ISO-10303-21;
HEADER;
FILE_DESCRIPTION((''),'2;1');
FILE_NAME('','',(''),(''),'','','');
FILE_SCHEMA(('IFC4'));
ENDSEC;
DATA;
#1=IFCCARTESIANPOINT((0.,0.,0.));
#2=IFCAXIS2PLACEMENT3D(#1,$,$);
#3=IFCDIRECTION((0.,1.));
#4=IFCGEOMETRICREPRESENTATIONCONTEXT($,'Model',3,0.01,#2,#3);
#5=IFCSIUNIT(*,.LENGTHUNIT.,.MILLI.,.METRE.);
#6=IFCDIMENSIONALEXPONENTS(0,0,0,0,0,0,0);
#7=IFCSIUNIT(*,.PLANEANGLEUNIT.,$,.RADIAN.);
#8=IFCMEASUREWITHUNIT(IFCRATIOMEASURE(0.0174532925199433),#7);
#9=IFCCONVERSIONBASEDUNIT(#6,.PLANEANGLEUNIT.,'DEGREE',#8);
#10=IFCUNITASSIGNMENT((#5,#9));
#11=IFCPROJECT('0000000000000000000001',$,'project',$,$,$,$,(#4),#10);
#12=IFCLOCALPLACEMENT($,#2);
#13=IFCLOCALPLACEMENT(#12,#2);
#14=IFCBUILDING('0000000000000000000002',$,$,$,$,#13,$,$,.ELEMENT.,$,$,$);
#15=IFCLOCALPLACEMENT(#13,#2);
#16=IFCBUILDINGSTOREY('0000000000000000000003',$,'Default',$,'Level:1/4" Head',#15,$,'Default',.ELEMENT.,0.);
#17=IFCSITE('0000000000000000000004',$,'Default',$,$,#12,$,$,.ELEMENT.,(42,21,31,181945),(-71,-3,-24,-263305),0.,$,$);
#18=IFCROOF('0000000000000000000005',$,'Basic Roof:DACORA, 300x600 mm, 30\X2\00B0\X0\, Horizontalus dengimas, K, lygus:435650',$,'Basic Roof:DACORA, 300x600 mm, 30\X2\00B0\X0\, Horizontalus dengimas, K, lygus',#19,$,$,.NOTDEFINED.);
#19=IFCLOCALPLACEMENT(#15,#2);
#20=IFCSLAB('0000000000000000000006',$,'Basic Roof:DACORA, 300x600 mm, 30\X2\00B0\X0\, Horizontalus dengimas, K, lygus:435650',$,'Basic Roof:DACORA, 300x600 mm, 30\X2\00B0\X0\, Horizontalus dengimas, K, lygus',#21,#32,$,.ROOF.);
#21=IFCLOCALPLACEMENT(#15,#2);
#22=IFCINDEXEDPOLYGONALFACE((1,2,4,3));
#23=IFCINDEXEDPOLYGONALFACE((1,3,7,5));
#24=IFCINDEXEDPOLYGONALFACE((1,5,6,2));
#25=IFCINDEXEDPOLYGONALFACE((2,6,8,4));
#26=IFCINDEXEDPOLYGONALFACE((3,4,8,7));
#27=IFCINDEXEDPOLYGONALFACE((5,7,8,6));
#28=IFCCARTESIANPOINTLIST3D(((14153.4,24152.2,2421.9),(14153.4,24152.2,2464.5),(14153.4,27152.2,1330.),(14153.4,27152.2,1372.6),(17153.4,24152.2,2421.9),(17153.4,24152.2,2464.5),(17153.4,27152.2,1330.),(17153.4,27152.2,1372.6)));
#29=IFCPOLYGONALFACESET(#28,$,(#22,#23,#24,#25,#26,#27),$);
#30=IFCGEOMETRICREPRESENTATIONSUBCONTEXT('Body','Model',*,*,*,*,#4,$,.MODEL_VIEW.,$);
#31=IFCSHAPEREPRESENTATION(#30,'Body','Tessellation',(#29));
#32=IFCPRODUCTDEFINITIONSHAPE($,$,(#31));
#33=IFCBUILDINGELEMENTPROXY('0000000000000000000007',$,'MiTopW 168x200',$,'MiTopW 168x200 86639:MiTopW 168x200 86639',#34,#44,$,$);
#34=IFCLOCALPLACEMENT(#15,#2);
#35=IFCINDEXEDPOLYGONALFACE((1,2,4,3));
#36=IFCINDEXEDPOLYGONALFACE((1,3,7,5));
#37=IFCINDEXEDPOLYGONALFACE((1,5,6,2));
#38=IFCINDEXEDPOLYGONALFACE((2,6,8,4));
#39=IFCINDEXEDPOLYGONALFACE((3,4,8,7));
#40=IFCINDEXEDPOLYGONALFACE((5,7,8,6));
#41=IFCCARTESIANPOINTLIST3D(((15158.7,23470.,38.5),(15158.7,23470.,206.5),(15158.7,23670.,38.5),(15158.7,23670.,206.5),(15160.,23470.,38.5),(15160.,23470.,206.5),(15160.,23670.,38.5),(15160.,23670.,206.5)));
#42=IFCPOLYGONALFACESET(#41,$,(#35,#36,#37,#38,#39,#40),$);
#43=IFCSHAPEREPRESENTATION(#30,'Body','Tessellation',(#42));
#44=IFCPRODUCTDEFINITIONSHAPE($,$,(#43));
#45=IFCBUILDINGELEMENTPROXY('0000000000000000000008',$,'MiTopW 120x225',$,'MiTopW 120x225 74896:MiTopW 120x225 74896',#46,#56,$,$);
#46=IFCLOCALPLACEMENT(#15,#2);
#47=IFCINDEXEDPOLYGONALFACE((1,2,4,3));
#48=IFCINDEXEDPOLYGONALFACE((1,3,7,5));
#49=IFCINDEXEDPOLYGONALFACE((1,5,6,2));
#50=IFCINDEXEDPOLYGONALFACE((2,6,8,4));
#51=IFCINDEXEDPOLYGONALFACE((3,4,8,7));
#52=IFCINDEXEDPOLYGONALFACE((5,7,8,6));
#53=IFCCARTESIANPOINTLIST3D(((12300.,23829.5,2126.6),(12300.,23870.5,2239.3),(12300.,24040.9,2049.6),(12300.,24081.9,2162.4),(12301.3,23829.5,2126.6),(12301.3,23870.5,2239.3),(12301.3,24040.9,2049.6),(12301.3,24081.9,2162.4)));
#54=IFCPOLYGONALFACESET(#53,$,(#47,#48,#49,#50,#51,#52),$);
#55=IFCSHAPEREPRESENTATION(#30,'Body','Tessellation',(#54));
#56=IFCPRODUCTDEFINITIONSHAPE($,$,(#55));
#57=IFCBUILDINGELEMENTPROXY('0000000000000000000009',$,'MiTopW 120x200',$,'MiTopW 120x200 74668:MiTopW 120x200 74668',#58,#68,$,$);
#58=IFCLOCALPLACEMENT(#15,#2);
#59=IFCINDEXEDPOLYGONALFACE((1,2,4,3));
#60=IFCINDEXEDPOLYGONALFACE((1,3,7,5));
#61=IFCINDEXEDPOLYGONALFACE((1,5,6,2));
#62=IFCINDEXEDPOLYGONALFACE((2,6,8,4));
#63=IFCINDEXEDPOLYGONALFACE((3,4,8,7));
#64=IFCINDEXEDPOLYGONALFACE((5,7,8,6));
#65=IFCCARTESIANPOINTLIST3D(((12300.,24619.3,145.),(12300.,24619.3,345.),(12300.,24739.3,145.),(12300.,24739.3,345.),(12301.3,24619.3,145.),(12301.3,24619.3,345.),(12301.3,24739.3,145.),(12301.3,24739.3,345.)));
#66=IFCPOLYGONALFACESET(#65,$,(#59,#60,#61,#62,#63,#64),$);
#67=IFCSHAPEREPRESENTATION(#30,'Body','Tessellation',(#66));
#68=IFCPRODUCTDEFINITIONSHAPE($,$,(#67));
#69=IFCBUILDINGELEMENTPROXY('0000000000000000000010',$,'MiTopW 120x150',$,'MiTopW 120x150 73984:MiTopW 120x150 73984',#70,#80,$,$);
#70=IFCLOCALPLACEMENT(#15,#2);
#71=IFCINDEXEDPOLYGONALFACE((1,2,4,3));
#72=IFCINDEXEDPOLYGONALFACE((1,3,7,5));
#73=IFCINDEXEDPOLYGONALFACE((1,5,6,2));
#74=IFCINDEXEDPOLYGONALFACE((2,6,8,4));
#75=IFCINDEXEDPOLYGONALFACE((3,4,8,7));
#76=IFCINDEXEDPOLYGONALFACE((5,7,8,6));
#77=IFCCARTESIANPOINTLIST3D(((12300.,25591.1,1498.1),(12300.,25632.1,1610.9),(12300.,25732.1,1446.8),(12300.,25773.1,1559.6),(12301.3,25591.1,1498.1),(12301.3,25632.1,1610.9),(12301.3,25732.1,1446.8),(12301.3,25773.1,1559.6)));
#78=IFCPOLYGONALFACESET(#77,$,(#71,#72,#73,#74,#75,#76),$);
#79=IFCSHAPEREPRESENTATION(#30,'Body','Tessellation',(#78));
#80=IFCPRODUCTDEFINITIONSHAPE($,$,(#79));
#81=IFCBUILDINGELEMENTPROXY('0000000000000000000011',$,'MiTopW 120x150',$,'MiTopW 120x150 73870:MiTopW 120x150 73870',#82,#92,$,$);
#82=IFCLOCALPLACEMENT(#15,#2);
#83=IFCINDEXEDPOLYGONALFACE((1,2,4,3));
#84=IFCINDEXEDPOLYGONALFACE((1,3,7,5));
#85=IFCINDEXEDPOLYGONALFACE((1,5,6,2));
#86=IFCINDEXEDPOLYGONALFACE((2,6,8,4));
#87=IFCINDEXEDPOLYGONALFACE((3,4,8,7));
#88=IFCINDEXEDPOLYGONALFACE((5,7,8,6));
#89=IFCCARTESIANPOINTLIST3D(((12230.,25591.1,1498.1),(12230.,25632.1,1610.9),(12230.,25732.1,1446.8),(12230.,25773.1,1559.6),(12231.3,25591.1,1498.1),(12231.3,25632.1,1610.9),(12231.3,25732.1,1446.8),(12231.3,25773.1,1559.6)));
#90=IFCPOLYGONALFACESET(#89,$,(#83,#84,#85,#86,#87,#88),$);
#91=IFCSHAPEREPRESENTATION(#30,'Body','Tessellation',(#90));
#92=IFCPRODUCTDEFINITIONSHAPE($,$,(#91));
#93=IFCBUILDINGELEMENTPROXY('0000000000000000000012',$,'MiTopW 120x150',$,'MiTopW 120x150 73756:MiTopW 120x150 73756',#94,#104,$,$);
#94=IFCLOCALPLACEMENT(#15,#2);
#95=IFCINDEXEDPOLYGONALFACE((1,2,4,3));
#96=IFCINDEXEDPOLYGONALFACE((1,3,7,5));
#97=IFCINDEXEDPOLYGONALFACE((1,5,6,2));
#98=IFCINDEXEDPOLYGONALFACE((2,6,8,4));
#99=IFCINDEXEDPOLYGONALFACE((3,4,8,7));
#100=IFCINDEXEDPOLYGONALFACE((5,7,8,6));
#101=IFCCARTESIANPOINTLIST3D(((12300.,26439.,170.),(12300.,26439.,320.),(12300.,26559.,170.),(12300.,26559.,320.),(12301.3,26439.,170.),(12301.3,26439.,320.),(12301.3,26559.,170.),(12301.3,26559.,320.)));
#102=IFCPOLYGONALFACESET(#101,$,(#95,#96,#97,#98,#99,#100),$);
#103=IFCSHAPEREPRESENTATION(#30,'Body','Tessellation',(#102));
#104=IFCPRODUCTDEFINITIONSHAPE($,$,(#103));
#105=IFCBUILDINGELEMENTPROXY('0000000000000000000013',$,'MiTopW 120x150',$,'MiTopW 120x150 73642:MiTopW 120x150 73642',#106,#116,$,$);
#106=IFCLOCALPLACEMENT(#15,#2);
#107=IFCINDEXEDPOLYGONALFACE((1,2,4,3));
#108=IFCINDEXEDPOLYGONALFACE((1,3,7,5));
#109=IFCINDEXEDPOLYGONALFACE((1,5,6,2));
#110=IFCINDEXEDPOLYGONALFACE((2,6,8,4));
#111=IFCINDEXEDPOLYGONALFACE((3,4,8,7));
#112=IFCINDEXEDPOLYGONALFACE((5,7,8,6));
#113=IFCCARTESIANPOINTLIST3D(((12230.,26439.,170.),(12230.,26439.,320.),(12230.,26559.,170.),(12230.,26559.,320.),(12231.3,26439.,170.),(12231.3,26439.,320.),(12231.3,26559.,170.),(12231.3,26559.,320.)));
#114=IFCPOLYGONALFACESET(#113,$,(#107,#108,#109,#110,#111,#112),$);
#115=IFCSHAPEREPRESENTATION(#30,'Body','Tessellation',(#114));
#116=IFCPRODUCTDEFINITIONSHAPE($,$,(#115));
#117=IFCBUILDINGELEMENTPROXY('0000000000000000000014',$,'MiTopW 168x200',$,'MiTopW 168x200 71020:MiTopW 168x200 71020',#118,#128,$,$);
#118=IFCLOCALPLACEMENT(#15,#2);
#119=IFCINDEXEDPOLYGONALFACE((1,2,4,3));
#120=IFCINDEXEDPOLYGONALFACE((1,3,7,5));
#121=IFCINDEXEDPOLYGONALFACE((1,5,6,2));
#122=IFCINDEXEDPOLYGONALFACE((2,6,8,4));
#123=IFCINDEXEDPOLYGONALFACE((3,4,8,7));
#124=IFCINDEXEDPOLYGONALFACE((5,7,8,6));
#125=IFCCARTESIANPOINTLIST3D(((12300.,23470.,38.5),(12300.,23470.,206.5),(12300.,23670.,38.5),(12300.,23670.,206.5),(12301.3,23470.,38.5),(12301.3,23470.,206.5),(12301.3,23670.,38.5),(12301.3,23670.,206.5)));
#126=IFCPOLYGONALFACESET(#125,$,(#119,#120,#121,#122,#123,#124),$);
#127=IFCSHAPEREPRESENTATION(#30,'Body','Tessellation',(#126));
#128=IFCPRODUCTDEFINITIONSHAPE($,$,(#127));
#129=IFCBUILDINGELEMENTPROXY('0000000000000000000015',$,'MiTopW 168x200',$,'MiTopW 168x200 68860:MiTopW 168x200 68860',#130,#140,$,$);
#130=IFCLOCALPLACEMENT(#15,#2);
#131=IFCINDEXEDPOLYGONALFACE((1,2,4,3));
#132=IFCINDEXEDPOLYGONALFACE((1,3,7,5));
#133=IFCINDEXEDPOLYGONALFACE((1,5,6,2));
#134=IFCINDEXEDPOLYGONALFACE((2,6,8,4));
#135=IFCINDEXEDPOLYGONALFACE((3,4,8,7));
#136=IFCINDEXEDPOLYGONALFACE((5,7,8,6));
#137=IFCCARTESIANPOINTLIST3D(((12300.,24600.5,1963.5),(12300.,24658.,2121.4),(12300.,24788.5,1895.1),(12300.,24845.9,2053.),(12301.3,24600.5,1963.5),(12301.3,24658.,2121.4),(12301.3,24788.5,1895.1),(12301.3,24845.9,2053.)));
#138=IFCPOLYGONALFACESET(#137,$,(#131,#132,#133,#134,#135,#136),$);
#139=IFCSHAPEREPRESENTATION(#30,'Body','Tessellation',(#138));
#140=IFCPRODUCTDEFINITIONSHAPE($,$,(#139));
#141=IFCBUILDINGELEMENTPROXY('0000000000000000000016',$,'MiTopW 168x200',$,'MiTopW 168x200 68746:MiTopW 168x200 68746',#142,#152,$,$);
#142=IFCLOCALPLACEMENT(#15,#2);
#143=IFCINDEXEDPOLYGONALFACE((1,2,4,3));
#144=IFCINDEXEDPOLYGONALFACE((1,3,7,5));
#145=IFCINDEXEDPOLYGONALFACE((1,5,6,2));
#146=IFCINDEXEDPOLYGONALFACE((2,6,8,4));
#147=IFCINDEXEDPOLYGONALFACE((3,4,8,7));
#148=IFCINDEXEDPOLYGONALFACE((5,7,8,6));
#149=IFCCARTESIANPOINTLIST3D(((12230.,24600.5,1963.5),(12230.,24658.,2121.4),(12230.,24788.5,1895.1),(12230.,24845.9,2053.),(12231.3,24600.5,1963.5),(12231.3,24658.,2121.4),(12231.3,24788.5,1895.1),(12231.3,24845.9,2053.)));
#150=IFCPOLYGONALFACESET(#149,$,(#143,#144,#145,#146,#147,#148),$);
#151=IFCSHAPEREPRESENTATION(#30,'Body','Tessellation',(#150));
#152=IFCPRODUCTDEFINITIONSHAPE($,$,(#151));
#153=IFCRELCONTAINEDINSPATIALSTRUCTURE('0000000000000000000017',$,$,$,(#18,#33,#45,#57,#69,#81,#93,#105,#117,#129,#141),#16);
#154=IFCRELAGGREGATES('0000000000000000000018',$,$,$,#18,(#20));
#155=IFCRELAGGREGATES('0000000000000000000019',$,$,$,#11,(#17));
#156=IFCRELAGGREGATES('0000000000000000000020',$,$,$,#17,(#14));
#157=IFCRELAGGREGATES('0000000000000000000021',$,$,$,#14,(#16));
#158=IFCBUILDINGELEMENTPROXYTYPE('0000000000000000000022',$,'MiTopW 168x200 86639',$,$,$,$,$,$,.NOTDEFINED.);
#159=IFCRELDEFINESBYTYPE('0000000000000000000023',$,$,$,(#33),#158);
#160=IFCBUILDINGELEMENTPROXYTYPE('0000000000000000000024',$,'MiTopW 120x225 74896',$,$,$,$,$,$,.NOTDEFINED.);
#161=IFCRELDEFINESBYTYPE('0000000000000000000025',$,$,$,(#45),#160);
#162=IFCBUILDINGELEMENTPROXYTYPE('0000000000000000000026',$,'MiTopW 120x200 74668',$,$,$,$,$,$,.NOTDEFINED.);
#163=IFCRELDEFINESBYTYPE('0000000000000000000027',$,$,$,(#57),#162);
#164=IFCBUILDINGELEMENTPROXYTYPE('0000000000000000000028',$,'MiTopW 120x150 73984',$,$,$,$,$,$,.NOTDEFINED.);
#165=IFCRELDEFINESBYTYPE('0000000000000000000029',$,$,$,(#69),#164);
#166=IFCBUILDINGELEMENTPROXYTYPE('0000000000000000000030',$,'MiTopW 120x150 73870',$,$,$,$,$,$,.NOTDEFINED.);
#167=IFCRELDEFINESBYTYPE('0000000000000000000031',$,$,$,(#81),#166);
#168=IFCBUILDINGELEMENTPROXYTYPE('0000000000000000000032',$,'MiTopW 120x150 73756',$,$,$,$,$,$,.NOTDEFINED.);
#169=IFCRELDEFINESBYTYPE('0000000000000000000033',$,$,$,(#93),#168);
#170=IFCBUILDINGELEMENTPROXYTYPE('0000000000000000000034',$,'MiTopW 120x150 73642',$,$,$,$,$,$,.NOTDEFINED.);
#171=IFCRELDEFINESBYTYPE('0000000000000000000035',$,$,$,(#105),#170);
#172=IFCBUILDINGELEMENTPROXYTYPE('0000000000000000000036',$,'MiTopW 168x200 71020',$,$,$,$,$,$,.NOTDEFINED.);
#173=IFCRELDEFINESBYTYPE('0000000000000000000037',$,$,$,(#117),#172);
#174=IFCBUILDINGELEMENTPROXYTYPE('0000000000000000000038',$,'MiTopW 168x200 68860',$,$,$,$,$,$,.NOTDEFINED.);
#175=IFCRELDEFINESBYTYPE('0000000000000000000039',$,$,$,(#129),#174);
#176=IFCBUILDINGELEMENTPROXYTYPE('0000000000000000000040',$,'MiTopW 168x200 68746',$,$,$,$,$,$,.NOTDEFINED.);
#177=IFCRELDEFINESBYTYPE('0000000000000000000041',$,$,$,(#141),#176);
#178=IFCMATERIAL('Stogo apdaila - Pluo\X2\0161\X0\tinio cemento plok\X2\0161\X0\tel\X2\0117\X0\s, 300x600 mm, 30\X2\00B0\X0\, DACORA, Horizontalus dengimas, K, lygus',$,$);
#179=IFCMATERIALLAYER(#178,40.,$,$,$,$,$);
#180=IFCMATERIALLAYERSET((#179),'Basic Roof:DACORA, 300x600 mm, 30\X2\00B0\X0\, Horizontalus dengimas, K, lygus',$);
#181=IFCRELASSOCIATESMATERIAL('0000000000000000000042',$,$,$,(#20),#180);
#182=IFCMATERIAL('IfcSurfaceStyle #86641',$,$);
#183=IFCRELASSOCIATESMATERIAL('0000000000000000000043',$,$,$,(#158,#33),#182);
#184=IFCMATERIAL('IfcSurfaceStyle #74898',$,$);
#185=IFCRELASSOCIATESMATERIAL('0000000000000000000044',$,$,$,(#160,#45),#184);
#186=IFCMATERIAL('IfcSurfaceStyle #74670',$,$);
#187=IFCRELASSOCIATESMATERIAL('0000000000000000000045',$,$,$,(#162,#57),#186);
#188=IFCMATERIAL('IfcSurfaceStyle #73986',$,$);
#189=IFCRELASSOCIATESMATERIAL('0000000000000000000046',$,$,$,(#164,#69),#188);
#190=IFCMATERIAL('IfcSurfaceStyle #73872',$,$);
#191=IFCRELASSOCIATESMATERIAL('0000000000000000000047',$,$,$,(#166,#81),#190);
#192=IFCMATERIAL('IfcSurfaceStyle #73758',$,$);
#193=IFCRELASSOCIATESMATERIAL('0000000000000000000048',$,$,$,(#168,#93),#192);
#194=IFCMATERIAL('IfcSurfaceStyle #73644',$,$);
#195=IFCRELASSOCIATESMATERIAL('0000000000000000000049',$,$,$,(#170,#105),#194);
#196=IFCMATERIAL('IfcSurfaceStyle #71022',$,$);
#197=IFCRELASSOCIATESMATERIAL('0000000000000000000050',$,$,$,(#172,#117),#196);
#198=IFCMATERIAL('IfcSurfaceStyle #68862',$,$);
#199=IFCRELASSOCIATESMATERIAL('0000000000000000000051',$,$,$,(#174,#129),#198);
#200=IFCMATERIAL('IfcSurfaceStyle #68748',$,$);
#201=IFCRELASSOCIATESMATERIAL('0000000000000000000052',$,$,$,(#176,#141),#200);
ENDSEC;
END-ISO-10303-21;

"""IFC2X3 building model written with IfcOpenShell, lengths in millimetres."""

from ifc_helpers import new_model, entity, si_unit, converted_unit, direction, frame, frame_2d, origin, origin_2d_with_axis, place, context, subcontext, project, spatial, polyline, rectangle, outline, extrude, source, transform, mapped, material, layer, layer_set, type_object, type_shapes, element, aggregate, save


model = new_model("IFC2X3")

# Units and contexts
model_context = context("Model", 3, precision=0.01, world=origin(), true_north=direction((0.0, 1.0)))
body_context = subcontext(model_context, "Body", "Model", "MODEL_VIEW")
ifc_project = project(units=[si_unit("LENGTHUNIT", "METRE", prefix="MILLI"), converted_unit("PLANEANGLEUNIT", "DEGREE", entity("IfcRatioMeasure", 0.0174532925199433), si_unit("PLANEANGLEUNIT", "RADIAN"), dimensions=[0, 0, 0, 0, 0, 0, 0])], contexts=[model_context])

# Site, building, storey
site_placement = place(None, origin())
site = spatial("IfcSite", under=ifc_project, at=site_placement, Name="Default", CompositionType="ELEMENT", RefLatitude=(42, 21, 31, 181945), RefLongitude=(-71, -3, -24, -263305), RefElevation=0.0)
building_placement = place(site_placement, origin())
building = spatial("IfcBuilding", under=site, at=building_placement, CompositionType="ELEMENT")
storey_placement = place(building_placement, origin())
storey = spatial("IfcBuildingStorey", under=building, at=storey_placement, Name="Default", ObjectType="Level:1/4\" Head", LongName="Default", CompositionType="ELEMENT", Elevation=0.0)

# Roof, slab
roof_placement = place(storey_placement, frame((14153.4, 24152.2, 1330.0)))
roof = element("IfcRoof", 1, at=roof_placement, inside=storey, Name="Basic Roof:DACORA, 300x600 mm, 30°, Horizontalus dengimas, K, lygus:435650", ObjectType="Basic Roof:DACORA, 300x600 mm, 30°, Horizontalus dengimas, K, lygus", ShapeType="NOTDEFINED")
ifc_material_1 = material(Name="Stogo apdaila - Pluoštinio cemento plokštelės, 300x600 mm, 30°, DACORA, Horizontalus dengimas, K, lygus")
ifc_layer = layer(ifc_material_1, 40.0)
ifc_layer_set = layer_set([ifc_layer], Name="Basic Roof:DACORA, 300x600 mm, 30°, Horizontalus dengimas, K, lygus")
slab_placement = place(roof_placement, origin())
slab = element("IfcSlab", 2, at=slab_placement, material=ifc_layer_set, Name="Basic Roof:DACORA, 300x600 mm, 30°, Horizontalus dengimas, K, lygus:435650", ObjectType="Basic Roof:DACORA, 300x600 mm, 30°, Horizontalus dengimas, K, lygus", PredefinedType="ROOF", context=body_context, shape_type="SweptSolid", body=[
    extrude(rectangle(XDim=3192.5, YDim=3000.0, at=frame_2d((0.0, 0.0), x_axis=(0.0, 1.0))), frame((1500.0, 1500.0, 546.0), z_axis=(0.0, 0.34202, 0.939693), x_axis=(1.0, 0.0, 0.0)), (0.0, -0.34202, 0.939693), 42.6),
])
aggregate(roof, [slab])

# Building element proxies
ifc_material_2 = material(Name="IfcSurfaceStyle #86641")
building_element_proxy_type_1 = type_object("IfcBuildingElementProxyType", Name="MiTopW 168x200 86639", PredefinedType="NOTDEFINED", material=ifc_material_2)
shared_shape_1 = source(origin(), body_context, "Body", "SweptSolid", [
    extrude(rectangle(XDim=200.0, YDim=168.0, at=origin_2d_with_axis()), frame((100.0, 84.0, 0.0), z_axis=(0.0, 0.0, 1.0), x_axis=(-1.0, 0.0, 0.0)), (0.0, 0.0, 1.0), 1.3),
])
type_shapes(building_element_proxy_type_1, [shared_shape_1])
proxy_1_placement = place(building_placement, frame((15160.0, 23470.0, 206.5), z_axis=(-1.0, 0.0, 0.0), x_axis=(0.0, 1.0, 0.0)))
element("IfcBuildingElementProxy", 3, at=proxy_1_placement, inside=storey, type_object=building_element_proxy_type_1, material=ifc_material_2, Name="MiTopW 168x200", ObjectType="MiTopW 168x200 86639:MiTopW 168x200 86639", context=body_context, shape_type="MappedRepresentation", body=[
    mapped(shared_shape_1, transform((0.0, 0.0, 0.0), scale=1.0)),
])
ifc_material_3 = material(Name="IfcSurfaceStyle #74898")
building_element_proxy_type_2 = type_object("IfcBuildingElementProxyType", Name="MiTopW 120x225 74896", PredefinedType="NOTDEFINED", material=ifc_material_3)
shared_shape_2 = source(origin(), body_context, "Body", "SweptSolid", [
    extrude(outline(polyline([(-112.5, -60.0), (112.5, -60.0), (112.5, 60.0), (-112.5, 60.0), (-112.5, -60.0)])), frame((112.5, 60.0, 0.0), z_axis=(0.0, 0.0, 1.0), x_axis=(-1.0, 0.0, 0.0)), (0.0, 0.0, 1.0), 1.3),
])
type_shapes(building_element_proxy_type_2, [shared_shape_2])
proxy_2_placement = place(building_placement, frame((12301.3, 24040.9, 2049.6), z_axis=(-1.0, 0.0, 0.0), x_axis=(0.0, -0.939693, 0.34202)))
element("IfcBuildingElementProxy", 4, at=proxy_2_placement, inside=storey, type_object=building_element_proxy_type_2, material=ifc_material_3, Name="MiTopW 120x225", ObjectType="MiTopW 120x225 74896:MiTopW 120x225 74896", context=body_context, shape_type="MappedRepresentation", body=[
    mapped(shared_shape_2, transform((0.0, 0.0, 0.0), scale=1.0)),
])
ifc_material_4 = material(Name="IfcSurfaceStyle #74670")
building_element_proxy_type_3 = type_object("IfcBuildingElementProxyType", Name="MiTopW 120x200 74668", PredefinedType="NOTDEFINED", material=ifc_material_4)
shared_shape_3 = source(origin(), body_context, "Body", "SweptSolid", [
    extrude(rectangle(XDim=200.0, YDim=120.0, at=origin_2d_with_axis()), frame((100.0, 60.0, 0.0), z_axis=(0.0, 0.0, 1.0), x_axis=(-1.0, 0.0, 0.0)), (0.0, 0.0, 1.0), 1.3),
])
type_shapes(building_element_proxy_type_3, [shared_shape_3])
proxy_3_placement = place(building_placement, frame((12301.3, 24619.3, 145.0), z_axis=(-1.0, 0.0, 0.0), x_axis=(0.0, 0.0, 1.0)))
element("IfcBuildingElementProxy", 5, at=proxy_3_placement, inside=storey, type_object=building_element_proxy_type_3, material=ifc_material_4, Name="MiTopW 120x200", ObjectType="MiTopW 120x200 74668:MiTopW 120x200 74668", context=body_context, shape_type="MappedRepresentation", body=[
    mapped(shared_shape_3, transform((0.0, 0.0, 0.0), scale=1.0)),
])
ifc_material_5 = material(Name="IfcSurfaceStyle #73986")
building_element_proxy_type_4 = type_object("IfcBuildingElementProxyType", Name="MiTopW 120x150 73984", PredefinedType="NOTDEFINED", material=ifc_material_5)
shared_shape_4 = source(origin(), body_context, "Body", "SweptSolid", [
    extrude(outline(polyline([(-75.0, -60.0), (75.0, -60.0), (75.0, 60.0), (-75.0, 60.0), (-75.0, -60.0)])), frame((75.0, 60.0, 0.0), z_axis=(0.0, 0.0, 1.0), x_axis=(-1.0, 0.0, 0.0)), (0.0, 0.0, 1.0), 1.3),
])
type_shapes(building_element_proxy_type_4, [shared_shape_4])
proxy_4_placement = place(building_placement, frame((12301.3, 25732.1, 1446.8), z_axis=(-1.0, 0.0, 0.0), x_axis=(0.0, -0.939693, 0.34202)))
element("IfcBuildingElementProxy", 6, at=proxy_4_placement, inside=storey, type_object=building_element_proxy_type_4, material=ifc_material_5, Name="MiTopW 120x150", ObjectType="MiTopW 120x150 73984:MiTopW 120x150 73984", context=body_context, shape_type="MappedRepresentation", body=[
    mapped(shared_shape_4, transform((0.0, 0.0, 0.0), scale=1.0)),
])
ifc_material_6 = material(Name="IfcSurfaceStyle #73872")
building_element_proxy_type_5 = type_object("IfcBuildingElementProxyType", Name="MiTopW 120x150 73870", PredefinedType="NOTDEFINED", material=ifc_material_6)
shared_shape_5 = source(origin(), body_context, "Body", "SweptSolid", [
    extrude(outline(polyline([(-75.0, -60.0), (75.0, -60.0), (75.0, 60.0), (-75.0, 60.0), (-75.0, -60.0)])), frame((75.0, 60.0, 0.0), z_axis=(0.0, 0.0, 1.0), x_axis=(-1.0, 0.0, 0.0)), (0.0, 0.0, 1.0), 1.3),
])
type_shapes(building_element_proxy_type_5, [shared_shape_5])
proxy_5_placement = place(building_placement, frame((12231.3, 25732.1, 1446.8), z_axis=(-1.0, 0.0, 0.0), x_axis=(0.0, -0.939693, 0.34202)))
element("IfcBuildingElementProxy", 7, at=proxy_5_placement, inside=storey, type_object=building_element_proxy_type_5, material=ifc_material_6, Name="MiTopW 120x150", ObjectType="MiTopW 120x150 73870:MiTopW 120x150 73870", context=body_context, shape_type="MappedRepresentation", body=[
    mapped(shared_shape_5, transform((0.0, 0.0, 0.0), scale=1.0)),
])
ifc_material_7 = material(Name="IfcSurfaceStyle #73758")
building_element_proxy_type_6 = type_object("IfcBuildingElementProxyType", Name="MiTopW 120x150 73756", PredefinedType="NOTDEFINED", material=ifc_material_7)
shared_shape_6 = source(origin(), body_context, "Body", "SweptSolid", [
    extrude(rectangle(XDim=150.0, YDim=120.0, at=frame_2d((0.0, 0.0), x_axis=(1.0, 0.0))), frame((75.0, 60.0, 0.0), z_axis=(0.0, 0.0, 1.0), x_axis=(-1.0, 0.0, 0.0)), (0.0, 0.0, 1.0), 1.3),
])
type_shapes(building_element_proxy_type_6, [shared_shape_6])
proxy_6_placement = place(building_placement, frame((12301.3, 26439.0, 170.0), z_axis=(-1.0, 0.0, 0.0), x_axis=(0.0, 0.0, 1.0)))
element("IfcBuildingElementProxy", 8, at=proxy_6_placement, inside=storey, type_object=building_element_proxy_type_6, material=ifc_material_7, Name="MiTopW 120x150", ObjectType="MiTopW 120x150 73756:MiTopW 120x150 73756", context=body_context, shape_type="MappedRepresentation", body=[
    mapped(shared_shape_6, transform((0.0, 0.0, 0.0), scale=1.0)),
])
ifc_material_8 = material(Name="IfcSurfaceStyle #73644")
building_element_proxy_type_7 = type_object("IfcBuildingElementProxyType", Name="MiTopW 120x150 73642", PredefinedType="NOTDEFINED", material=ifc_material_8)
shared_shape_7 = source(origin(), body_context, "Body", "SweptSolid", [
    extrude(rectangle(XDim=150.0, YDim=120.0, at=frame_2d((0.0, 0.0), x_axis=(1.0, 0.0))), frame((75.0, 60.0, 0.0), z_axis=(0.0, 0.0, 1.0), x_axis=(-1.0, 0.0, 0.0)), (0.0, 0.0, 1.0), 1.3),
])
type_shapes(building_element_proxy_type_7, [shared_shape_7])
proxy_7_placement = place(building_placement, frame((12231.3, 26439.0, 170.0), z_axis=(-1.0, 0.0, 0.0), x_axis=(0.0, 0.0, 1.0)))
element("IfcBuildingElementProxy", 9, at=proxy_7_placement, inside=storey, type_object=building_element_proxy_type_7, material=ifc_material_8, Name="MiTopW 120x150", ObjectType="MiTopW 120x150 73642:MiTopW 120x150 73642", context=body_context, shape_type="MappedRepresentation", body=[
    mapped(shared_shape_7, transform((0.0, 0.0, 0.0), scale=1.0)),
])
ifc_material_9 = material(Name="IfcSurfaceStyle #71022")
building_element_proxy_type_8 = type_object("IfcBuildingElementProxyType", Name="MiTopW 168x200 71020", PredefinedType="NOTDEFINED", material=ifc_material_9)
shared_shape_8 = source(origin(), body_context, "Body", "SweptSolid", [
    extrude(rectangle(XDim=200.0, YDim=168.0, at=origin_2d_with_axis()), frame((100.0, 84.0, 0.0), z_axis=(0.0, 0.0, 1.0), x_axis=(-1.0, 0.0, 0.0)), (0.0, 0.0, 1.0), 1.3),
])
type_shapes(building_element_proxy_type_8, [shared_shape_8])
proxy_8_placement = place(building_placement, frame((12301.3, 23470.0, 206.5), z_axis=(-1.0, 0.0, 0.0), x_axis=(0.0, 1.0, 0.0)))
element("IfcBuildingElementProxy", 10, at=proxy_8_placement, inside=storey, type_object=building_element_proxy_type_8, material=ifc_material_9, Name="MiTopW 168x200", ObjectType="MiTopW 168x200 71020:MiTopW 168x200 71020", context=body_context, shape_type="MappedRepresentation", body=[
    mapped(shared_shape_8, transform((0.0, 0.0, 0.0), scale=1.0)),
])
ifc_material_10 = material(Name="IfcSurfaceStyle #68862")
building_element_proxy_type_9 = type_object("IfcBuildingElementProxyType", Name="MiTopW 168x200 68860", PredefinedType="NOTDEFINED", material=ifc_material_10)
shared_shape_9 = source(origin(), body_context, "Body", "SweptSolid", [
    extrude(outline(polyline([(-100.0, -84.0), (100.0, -84.0), (100.0, 84.0), (-100.0, 84.0), (-100.0, -84.0)])), frame((100.0, 84.0, 0.0), z_axis=(0.0, 0.0, 1.0), x_axis=(-1.0, 0.0, 0.0)), (0.0, 0.0, 1.0), 1.3),
])
type_shapes(building_element_proxy_type_9, [shared_shape_9])
proxy_9_placement = place(building_placement, frame((12301.3, 24788.5, 1895.1), z_axis=(-1.0, 0.0, 0.0), x_axis=(0.0, -0.939693, 0.34202)))
element("IfcBuildingElementProxy", 11, at=proxy_9_placement, inside=storey, type_object=building_element_proxy_type_9, material=ifc_material_10, Name="MiTopW 168x200", ObjectType="MiTopW 168x200 68860:MiTopW 168x200 68860", context=body_context, shape_type="MappedRepresentation", body=[
    mapped(shared_shape_9, transform((0.0, 0.0, 0.0), scale=1.0)),
])
ifc_material_11 = material(Name="IfcSurfaceStyle #68748")
building_element_proxy_type_10 = type_object("IfcBuildingElementProxyType", Name="MiTopW 168x200 68746", PredefinedType="NOTDEFINED", material=ifc_material_11)
shared_shape_10 = source(origin(), body_context, "Body", "SweptSolid", [
    extrude(outline(polyline([(-100.0, -84.0), (100.0, -84.0), (100.0, 84.0), (-100.0, 84.0), (-100.0, -84.0)])), frame((100.0, 84.0, 0.0), z_axis=(0.0, 0.0, 1.0), x_axis=(-1.0, 0.0, 0.0)), (0.0, 0.0, 1.0), 1.3),
])
type_shapes(building_element_proxy_type_10, [shared_shape_10])
proxy_10_placement = place(building_placement, frame((12231.3, 24788.5, 1895.1), z_axis=(-1.0, 0.0, 0.0), x_axis=(0.0, -0.939693, 0.34202)))
element("IfcBuildingElementProxy", 12, at=proxy_10_placement, inside=storey, type_object=building_element_proxy_type_10, material=ifc_material_11, Name="MiTopW 168x200", ObjectType="MiTopW 168x200 68746:MiTopW 168x200 68746", context=body_context, shape_type="MappedRepresentation", body=[
    mapped(shared_shape_10, transform((0.0, 0.0, 0.0), scale=1.0)),
])

save(model, "model.ifc")
